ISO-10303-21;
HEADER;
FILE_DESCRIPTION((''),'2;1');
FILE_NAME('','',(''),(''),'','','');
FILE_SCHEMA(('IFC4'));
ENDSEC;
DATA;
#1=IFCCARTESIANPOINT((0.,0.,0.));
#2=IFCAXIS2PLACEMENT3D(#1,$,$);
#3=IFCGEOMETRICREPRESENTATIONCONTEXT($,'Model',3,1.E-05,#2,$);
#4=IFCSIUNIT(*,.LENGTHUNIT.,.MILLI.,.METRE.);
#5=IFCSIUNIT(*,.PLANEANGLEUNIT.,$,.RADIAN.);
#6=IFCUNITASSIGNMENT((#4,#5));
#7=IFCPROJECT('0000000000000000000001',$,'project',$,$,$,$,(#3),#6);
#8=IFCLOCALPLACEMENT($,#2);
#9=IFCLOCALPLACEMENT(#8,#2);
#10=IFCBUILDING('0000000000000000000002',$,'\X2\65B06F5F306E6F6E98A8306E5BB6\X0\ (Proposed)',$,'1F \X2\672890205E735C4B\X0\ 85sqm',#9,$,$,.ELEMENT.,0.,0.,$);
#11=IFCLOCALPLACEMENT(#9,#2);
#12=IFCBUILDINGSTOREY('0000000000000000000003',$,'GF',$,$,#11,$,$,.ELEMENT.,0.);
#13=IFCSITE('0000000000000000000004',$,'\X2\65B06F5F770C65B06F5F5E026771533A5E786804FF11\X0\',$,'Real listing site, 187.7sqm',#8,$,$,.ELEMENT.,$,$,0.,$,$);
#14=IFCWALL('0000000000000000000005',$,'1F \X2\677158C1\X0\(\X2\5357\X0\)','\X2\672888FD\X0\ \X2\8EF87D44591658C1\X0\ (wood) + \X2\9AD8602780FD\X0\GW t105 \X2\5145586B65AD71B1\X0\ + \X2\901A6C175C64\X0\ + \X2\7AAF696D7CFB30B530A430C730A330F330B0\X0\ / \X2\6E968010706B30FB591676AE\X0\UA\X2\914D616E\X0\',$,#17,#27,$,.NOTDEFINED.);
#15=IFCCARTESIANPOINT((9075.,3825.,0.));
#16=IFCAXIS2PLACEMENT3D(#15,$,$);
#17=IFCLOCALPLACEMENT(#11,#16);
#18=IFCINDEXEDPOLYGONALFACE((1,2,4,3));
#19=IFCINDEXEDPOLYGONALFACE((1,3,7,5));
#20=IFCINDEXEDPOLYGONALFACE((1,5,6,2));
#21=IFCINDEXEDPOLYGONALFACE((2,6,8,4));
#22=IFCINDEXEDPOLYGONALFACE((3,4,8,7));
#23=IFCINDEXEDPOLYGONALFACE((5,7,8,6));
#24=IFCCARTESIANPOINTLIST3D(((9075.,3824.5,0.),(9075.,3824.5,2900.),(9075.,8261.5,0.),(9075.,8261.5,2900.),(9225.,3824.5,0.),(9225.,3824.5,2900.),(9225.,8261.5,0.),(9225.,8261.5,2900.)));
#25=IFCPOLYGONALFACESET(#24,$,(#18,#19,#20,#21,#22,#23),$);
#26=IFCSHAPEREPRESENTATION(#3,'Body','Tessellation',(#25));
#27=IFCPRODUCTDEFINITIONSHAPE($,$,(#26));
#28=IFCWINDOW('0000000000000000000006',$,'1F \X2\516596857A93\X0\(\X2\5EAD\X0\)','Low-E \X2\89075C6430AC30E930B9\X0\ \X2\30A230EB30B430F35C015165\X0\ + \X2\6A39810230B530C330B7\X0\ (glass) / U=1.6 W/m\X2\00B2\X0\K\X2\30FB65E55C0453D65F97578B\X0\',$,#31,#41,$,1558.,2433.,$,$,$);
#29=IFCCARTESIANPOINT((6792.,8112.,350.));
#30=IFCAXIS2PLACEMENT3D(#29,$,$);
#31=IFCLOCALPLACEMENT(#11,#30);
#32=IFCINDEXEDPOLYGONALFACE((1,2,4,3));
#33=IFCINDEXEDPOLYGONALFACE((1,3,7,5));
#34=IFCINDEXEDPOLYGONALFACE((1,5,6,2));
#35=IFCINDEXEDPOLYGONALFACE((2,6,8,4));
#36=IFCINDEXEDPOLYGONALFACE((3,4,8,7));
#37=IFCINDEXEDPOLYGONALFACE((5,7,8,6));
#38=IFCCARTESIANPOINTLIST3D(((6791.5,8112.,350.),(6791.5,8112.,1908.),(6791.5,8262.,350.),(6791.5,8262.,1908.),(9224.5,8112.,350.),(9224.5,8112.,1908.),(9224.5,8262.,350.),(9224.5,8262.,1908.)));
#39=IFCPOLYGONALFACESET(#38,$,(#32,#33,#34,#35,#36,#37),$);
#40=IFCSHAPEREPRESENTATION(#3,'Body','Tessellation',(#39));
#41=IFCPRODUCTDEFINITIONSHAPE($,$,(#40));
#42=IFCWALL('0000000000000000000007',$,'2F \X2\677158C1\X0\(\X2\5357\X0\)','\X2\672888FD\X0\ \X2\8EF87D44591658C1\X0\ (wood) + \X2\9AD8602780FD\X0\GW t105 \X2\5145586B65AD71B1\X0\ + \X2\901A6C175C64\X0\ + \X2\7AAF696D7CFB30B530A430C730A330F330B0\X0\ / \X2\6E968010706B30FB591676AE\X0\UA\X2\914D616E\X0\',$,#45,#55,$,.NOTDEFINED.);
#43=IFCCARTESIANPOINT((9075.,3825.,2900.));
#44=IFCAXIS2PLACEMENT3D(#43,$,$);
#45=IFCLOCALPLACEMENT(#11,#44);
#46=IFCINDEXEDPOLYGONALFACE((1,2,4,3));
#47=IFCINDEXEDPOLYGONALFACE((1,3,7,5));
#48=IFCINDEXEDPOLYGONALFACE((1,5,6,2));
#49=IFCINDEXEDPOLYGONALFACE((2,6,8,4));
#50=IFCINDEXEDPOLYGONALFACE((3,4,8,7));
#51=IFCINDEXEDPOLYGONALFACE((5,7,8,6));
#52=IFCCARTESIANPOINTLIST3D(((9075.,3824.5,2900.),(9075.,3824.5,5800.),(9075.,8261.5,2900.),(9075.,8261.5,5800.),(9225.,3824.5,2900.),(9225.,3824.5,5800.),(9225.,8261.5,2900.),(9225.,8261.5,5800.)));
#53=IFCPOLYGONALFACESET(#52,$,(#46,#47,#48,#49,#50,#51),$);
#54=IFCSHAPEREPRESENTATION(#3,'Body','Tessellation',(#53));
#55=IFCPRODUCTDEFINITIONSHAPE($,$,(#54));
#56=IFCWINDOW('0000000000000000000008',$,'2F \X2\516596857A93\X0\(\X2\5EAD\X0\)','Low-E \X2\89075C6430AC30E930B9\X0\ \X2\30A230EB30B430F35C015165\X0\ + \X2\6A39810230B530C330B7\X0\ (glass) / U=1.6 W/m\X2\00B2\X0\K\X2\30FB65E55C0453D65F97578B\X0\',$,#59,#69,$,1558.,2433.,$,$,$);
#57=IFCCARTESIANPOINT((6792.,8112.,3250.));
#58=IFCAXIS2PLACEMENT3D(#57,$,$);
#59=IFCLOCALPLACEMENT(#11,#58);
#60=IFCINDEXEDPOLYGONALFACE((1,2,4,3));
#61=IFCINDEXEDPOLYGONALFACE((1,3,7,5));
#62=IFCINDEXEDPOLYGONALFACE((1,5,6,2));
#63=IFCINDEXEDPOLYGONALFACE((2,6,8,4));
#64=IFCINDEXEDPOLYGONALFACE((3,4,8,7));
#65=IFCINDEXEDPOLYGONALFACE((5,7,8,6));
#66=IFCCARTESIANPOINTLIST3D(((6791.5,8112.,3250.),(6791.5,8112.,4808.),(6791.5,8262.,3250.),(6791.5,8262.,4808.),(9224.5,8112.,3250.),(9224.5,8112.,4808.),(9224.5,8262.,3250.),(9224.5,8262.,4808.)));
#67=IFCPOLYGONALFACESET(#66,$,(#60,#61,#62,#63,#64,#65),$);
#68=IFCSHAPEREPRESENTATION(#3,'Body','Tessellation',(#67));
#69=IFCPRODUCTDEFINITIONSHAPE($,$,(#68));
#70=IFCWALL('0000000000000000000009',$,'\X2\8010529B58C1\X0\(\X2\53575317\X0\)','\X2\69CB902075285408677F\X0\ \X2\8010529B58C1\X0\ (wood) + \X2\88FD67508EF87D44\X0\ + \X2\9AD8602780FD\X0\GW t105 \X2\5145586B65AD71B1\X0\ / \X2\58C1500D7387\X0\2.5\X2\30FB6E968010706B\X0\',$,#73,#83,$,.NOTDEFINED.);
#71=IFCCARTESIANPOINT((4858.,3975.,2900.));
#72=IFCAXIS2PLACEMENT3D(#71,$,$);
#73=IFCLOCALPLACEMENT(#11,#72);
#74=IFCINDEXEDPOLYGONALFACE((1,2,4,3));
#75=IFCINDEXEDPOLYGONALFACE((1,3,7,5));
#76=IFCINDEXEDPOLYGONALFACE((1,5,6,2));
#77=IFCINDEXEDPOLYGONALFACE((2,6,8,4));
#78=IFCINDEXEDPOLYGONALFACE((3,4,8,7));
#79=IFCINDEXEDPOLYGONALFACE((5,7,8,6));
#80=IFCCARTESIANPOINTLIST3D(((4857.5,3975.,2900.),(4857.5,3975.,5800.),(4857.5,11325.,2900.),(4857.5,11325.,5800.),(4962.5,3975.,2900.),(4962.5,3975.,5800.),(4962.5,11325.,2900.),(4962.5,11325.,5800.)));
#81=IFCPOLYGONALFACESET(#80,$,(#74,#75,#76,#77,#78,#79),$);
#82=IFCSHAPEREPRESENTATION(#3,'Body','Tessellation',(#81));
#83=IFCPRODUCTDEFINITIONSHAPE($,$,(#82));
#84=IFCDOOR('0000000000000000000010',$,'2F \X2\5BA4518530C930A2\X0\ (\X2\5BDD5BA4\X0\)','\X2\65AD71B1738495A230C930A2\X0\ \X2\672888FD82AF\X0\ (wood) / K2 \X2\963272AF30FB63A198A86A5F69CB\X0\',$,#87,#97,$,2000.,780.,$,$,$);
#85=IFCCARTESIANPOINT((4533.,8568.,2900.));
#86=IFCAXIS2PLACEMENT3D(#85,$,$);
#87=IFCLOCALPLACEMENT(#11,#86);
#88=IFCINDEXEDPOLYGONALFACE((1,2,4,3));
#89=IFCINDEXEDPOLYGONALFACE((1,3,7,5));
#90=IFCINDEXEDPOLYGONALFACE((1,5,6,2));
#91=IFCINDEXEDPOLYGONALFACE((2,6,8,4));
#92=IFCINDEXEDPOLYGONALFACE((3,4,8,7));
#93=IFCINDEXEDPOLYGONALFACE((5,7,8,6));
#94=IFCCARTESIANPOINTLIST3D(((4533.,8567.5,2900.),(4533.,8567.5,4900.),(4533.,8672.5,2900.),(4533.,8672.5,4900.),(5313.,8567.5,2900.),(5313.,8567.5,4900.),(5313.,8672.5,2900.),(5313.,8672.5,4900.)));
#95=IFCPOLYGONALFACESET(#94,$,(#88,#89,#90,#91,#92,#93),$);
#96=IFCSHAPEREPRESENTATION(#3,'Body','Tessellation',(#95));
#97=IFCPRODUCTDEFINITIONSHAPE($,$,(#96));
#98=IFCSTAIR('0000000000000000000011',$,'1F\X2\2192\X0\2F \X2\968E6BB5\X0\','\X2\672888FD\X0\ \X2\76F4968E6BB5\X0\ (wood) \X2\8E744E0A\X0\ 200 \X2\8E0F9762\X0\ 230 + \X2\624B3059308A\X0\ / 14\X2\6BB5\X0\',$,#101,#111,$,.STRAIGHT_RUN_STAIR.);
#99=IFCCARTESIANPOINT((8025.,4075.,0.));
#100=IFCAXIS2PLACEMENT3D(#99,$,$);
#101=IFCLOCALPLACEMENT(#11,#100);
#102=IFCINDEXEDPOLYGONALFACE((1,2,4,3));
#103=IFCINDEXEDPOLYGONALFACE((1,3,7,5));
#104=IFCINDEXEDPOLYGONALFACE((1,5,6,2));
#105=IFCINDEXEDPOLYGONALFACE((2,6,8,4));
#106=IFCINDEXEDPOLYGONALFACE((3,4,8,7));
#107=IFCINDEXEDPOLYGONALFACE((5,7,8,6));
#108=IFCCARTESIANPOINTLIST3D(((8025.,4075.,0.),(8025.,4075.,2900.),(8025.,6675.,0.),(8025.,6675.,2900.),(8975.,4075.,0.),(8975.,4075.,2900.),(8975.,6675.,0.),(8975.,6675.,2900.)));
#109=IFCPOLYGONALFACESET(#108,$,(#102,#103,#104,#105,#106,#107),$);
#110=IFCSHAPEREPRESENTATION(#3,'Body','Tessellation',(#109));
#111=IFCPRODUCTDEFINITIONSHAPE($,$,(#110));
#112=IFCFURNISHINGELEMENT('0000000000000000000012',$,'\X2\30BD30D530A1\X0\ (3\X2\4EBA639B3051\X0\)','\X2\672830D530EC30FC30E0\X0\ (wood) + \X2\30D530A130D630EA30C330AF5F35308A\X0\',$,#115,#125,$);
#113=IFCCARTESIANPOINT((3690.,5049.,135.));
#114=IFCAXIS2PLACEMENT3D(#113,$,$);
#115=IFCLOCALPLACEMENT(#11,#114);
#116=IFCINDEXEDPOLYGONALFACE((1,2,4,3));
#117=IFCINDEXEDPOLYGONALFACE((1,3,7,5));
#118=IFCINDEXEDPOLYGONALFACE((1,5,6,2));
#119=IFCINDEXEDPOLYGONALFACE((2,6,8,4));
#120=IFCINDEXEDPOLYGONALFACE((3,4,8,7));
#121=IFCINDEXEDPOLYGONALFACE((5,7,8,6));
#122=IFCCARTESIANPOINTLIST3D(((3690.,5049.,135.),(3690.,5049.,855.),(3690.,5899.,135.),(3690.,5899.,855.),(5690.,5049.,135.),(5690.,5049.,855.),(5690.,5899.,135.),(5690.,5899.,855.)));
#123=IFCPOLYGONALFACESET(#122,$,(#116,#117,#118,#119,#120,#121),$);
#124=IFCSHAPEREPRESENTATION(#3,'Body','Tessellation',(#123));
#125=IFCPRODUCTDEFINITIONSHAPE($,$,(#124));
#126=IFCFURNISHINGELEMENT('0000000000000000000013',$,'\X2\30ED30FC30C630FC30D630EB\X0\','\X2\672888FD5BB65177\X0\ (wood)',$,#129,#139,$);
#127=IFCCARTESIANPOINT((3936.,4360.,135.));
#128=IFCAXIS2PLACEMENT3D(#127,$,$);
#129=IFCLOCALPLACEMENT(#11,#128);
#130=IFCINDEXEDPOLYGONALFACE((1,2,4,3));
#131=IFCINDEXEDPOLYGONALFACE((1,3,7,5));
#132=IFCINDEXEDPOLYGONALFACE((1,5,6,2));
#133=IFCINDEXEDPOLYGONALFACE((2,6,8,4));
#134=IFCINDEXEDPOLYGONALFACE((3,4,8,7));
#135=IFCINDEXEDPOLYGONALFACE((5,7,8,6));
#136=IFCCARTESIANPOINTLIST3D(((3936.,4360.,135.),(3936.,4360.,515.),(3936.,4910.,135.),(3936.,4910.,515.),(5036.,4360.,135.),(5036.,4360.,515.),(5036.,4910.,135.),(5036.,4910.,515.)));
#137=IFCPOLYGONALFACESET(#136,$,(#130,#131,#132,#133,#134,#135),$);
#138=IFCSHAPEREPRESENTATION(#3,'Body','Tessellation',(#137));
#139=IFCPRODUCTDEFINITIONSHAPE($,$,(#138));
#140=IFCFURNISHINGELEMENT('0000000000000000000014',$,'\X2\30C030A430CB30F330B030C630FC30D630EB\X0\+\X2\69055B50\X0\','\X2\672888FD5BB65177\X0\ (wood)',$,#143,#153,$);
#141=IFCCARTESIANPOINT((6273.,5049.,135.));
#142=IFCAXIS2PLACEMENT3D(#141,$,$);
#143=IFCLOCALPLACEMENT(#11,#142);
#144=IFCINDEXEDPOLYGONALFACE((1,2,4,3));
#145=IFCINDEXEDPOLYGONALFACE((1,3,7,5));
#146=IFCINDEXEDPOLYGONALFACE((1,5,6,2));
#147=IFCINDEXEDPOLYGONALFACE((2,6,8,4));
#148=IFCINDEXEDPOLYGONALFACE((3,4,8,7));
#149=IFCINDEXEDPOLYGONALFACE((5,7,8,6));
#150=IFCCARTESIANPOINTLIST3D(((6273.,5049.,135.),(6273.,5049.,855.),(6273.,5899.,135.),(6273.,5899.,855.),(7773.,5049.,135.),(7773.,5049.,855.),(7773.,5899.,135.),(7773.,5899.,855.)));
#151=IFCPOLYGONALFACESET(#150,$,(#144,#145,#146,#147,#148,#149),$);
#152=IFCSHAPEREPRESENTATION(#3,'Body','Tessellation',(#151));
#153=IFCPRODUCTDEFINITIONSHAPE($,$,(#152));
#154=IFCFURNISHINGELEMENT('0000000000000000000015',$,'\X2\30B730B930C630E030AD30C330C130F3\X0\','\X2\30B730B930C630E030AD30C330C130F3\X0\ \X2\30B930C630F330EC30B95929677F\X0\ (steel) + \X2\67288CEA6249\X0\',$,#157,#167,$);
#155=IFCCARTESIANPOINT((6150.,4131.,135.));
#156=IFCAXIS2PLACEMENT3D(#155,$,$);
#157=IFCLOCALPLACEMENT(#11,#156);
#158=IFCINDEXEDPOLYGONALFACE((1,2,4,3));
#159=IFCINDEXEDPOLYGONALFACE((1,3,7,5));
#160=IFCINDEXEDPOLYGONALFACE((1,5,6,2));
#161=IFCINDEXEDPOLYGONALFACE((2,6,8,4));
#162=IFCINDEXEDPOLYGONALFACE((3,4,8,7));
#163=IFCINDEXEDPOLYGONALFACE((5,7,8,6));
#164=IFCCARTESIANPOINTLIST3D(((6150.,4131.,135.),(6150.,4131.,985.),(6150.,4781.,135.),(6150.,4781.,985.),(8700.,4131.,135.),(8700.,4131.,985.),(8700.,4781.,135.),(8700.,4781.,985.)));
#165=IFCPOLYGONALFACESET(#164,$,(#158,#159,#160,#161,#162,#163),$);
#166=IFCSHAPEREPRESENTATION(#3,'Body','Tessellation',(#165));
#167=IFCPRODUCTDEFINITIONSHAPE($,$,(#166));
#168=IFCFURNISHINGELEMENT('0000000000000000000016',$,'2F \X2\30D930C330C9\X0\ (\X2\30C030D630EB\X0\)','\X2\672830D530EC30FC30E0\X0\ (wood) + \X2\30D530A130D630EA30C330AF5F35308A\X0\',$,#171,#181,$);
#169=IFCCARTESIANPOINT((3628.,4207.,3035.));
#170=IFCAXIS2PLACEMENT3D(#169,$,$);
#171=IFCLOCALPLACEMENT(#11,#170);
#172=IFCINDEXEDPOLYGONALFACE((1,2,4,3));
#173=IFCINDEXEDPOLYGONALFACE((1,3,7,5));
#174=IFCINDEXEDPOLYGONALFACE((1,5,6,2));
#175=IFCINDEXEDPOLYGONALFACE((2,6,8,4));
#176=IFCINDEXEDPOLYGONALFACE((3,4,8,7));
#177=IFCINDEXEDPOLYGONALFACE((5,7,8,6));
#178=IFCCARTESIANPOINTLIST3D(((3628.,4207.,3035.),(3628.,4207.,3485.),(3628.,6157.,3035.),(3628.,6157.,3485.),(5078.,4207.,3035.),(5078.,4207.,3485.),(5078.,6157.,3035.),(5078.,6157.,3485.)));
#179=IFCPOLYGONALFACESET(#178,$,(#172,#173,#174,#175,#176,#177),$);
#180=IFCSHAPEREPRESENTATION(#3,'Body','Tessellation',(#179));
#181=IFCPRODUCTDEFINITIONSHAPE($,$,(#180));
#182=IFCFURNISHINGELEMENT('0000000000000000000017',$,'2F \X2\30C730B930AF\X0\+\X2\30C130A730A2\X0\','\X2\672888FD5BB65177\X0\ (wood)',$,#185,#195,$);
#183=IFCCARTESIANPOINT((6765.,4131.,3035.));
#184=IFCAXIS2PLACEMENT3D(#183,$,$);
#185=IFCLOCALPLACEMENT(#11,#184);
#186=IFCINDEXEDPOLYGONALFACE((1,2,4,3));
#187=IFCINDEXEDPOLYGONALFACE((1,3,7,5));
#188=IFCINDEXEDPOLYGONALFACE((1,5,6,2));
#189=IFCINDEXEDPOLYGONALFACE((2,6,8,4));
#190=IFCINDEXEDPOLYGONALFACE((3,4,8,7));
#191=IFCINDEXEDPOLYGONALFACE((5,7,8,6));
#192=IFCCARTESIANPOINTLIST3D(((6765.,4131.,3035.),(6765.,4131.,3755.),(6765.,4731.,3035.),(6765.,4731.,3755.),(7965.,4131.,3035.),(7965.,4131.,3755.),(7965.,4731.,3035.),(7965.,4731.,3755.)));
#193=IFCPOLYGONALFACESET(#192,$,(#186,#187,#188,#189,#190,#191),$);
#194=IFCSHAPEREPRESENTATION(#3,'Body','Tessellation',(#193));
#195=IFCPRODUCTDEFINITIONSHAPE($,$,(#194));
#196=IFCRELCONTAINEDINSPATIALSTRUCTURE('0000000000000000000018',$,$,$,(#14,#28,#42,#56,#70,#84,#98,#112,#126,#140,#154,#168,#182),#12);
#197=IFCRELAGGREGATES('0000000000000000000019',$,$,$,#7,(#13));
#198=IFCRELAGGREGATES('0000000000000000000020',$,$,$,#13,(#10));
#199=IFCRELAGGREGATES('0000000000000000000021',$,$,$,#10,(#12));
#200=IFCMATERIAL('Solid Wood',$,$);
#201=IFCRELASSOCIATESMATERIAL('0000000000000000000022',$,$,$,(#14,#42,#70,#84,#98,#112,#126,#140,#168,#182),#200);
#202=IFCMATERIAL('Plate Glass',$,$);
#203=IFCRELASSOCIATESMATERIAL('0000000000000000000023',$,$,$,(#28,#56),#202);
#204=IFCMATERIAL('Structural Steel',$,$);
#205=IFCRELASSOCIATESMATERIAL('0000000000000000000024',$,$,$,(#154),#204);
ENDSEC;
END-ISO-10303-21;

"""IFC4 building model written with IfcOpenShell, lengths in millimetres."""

from ifc_helpers import new_model, si_unit, frame, frame_2d, origin, place, context, project, spatial, rectangle, extrude, material, element, fill, save


model = new_model("IFC4")

# Units and contexts
model_context = context("Model", 3, precision=1e-05, world=origin())
ifc_project = project(units=[si_unit("LENGTHUNIT", "METRE", prefix="MILLI"), si_unit("PLANEANGLEUNIT", "RADIAN")], contexts=[model_context])

# Site, building, storey
site_placement = place(None, origin())
site = spatial("IfcSite", under=ifc_project, at=site_placement, Name="新潟県新潟市東区幸栄１", ObjectType="Real listing site, 187.7sqm", CompositionType="ELEMENT", RefElevation=0.0)
building_placement = place(site_placement, origin())
building = spatial("IfcBuilding", under=site, at=building_placement, Name="新潟の潮風の家 (Proposed)", ObjectType="1F 木造平屋 85sqm", CompositionType="ELEMENT", ElevationOfRefHeight=0.0, ElevationOfTerrain=0.0)
storey_placement = place(building_placement, origin())
storey = spatial("IfcBuildingStorey", under=building, at=storey_placement, Name="GF", CompositionType="ELEMENT", Elevation=0.0)

# Wall, opening, window
ifc_material_1 = material(Name="Solid Wood")
wall_1_placement = place(storey_placement, frame((9075.0, 3825.0, 0.0)))
wall_1 = element("IfcWall", 1, at=wall_1_placement, inside=storey, material=ifc_material_1, Name="1F 東壁(南)", Description="木製 軸組外壁 (wood) + 高性能GW t105 充填断熱 + 通気層 + 窯業系サイディング / 準耐火・外皮UA配慮", PredefinedType="NOTDEFINED", context=model_context, shape_type="SweptSolid", body=[
    extrude(rectangle(XDim=150.0, YDim=4437.0, at=frame_2d((75.0, 2218.0))), frame((9075.0, 3825.0, 0.0)), (0.0, 0.0, 1.0), 2900.0),
])
opening_1_placement = place(storey_placement, frame((6792.0, 8112.0, 350.0)))
opening_1 = element("IfcOpeningElement", 2, at=opening_1_placement, cuts=wall_1, PredefinedType="NOTDEFINED", context=model_context, shape_type="SweptSolid", body=[
    extrude(rectangle(XDim=2433.0, YDim=150.0, at=frame_2d((1216.0, 75.0))), frame((6792.0, 8112.0, 350.0)), (0.0, 0.0, 1.0), 1558.0),
])
ifc_material_2 = material(Name="Plate Glass")
window_1_placement = place(storey_placement, frame((6792.0, 8112.0, 350.0)))
window_1 = element("IfcWindow", 3, at=window_1_placement, inside=storey, material=ifc_material_2, Name="1F 入隅窓(庭)", Description="Low-E 複層ガラス アルゴン封入 + 樹脂サッシ (glass) / U=1.6 W/m²K・日射取得型", OverallHeight=1558.0, OverallWidth=2433.0, context=model_context, shape_type="SweptSolid", body=[
    extrude(rectangle(XDim=2433.0, YDim=150.0, at=frame_2d((1216.0, 75.0))), frame((6792.0, 8112.0, 350.0)), (0.0, 0.0, 1.0), 1558.0),
])
fill(opening_1, window_1)

# Wall, opening, window
wall_2_placement = place(storey_placement, frame((9075.0, 3825.0, 2900.0)))
wall_2 = element("IfcWall", 4, at=wall_2_placement, inside=storey, material=ifc_material_1, Name="2F 東壁(南)", Description="木製 軸組外壁 (wood) + 高性能GW t105 充填断熱 + 通気層 + 窯業系サイディング / 準耐火・外皮UA配慮", PredefinedType="NOTDEFINED", context=model_context, shape_type="SweptSolid", body=[
    extrude(rectangle(XDim=150.0, YDim=4437.0, at=frame_2d((75.0, 2218.0))), frame((9075.0, 3825.0, 2900.0)), (0.0, 0.0, 1.0), 2900.0),
])
opening_2_placement = place(storey_placement, frame((6792.0, 8112.0, 3250.0)))
opening_2 = element("IfcOpeningElement", 5, at=opening_2_placement, cuts=wall_2, PredefinedType="NOTDEFINED", context=model_context, shape_type="SweptSolid", body=[
    extrude(rectangle(XDim=2433.0, YDim=150.0, at=frame_2d((1216.0, 75.0))), frame((6792.0, 8112.0, 3250.0)), (0.0, 0.0, 1.0), 1558.0),
])
window_2_placement = place(storey_placement, frame((6792.0, 8112.0, 3250.0)))
window_2 = element("IfcWindow", 6, at=window_2_placement, inside=storey, material=ifc_material_2, Name="2F 入隅窓(庭)", Description="Low-E 複層ガラス アルゴン封入 + 樹脂サッシ (glass) / U=1.6 W/m²K・日射取得型", OverallHeight=1558.0, OverallWidth=2433.0, context=model_context, shape_type="SweptSolid", body=[
    extrude(rectangle(XDim=2433.0, YDim=150.0, at=frame_2d((1216.0, 75.0))), frame((6792.0, 8112.0, 3250.0)), (0.0, 0.0, 1.0), 1558.0),
])
fill(opening_2, window_2)

# Wall, opening, door
wall_3_placement = place(storey_placement, frame((4858.0, 3975.0, 2900.0)))
wall_3 = element("IfcWall", 7, at=wall_3_placement, inside=storey, material=ifc_material_1, Name="耐力壁(南北)", Description="構造用合板 耐力壁 (wood) + 製材軸組 + 高性能GW t105 充填断熱 / 壁倍率2.5・準耐火", PredefinedType="NOTDEFINED", context=model_context, shape_type="SweptSolid", body=[
    extrude(rectangle(XDim=105.0, YDim=7350.0, at=frame_2d((52.0, 3675.0))), frame((4858.0, 3975.0, 2900.0)), (0.0, 0.0, 1.0), 2900.0),
])
opening_3_placement = place(storey_placement, frame((4533.0, 8568.0, 2900.0)))
opening_3 = element("IfcOpeningElement", 8, at=opening_3_placement, cuts=wall_3, PredefinedType="NOTDEFINED", context=model_context, shape_type="SweptSolid", body=[
    extrude(rectangle(XDim=780.0, YDim=105.0, at=frame_2d((390.0, 52.0))), frame((4533.0, 8568.0, 2900.0)), (0.0, 0.0, 1.0), 2000.0),
])
door_1_placement = place(storey_placement, frame((4533.0, 8568.0, 2900.0)))
door_1 = element("IfcDoor", 9, at=door_1_placement, inside=storey, material=ifc_material_1, Name="2F 室内ドア (寝室)", Description="断熱玄関ドア 木製芯 (wood) / K2 防犯・採風機構", OverallHeight=2000.0, OverallWidth=780.0, context=model_context, shape_type="SweptSolid", body=[
    extrude(rectangle(XDim=780.0, YDim=105.0, at=frame_2d((390.0, 52.0))), frame((4533.0, 8568.0, 2900.0)), (0.0, 0.0, 1.0), 2000.0),
])
fill(opening_3, door_1)

# Stair
stair_placement = place(storey_placement, frame((8025.0, 4075.0, 0.0)))
element("IfcStair", 10, at=stair_placement, inside=storey, material=ifc_material_1, Name="1F→2F 階段", Description="木製 直階段 (wood) 蹴上 200 踏面 230 + 手すり / 14段", PredefinedType="STRAIGHT_RUN_STAIR", context=model_context, shape_type="SweptSolid", body=[
    extrude(rectangle(XDim=950.0, YDim=2600.0, at=frame_2d((475.0, 1300.0))), frame((8025.0, 4075.0, 0.0)), (0.0, 0.0, 1.0), 2900.0),
])

# Furnishing elements
furnishing_1_placement = place(storey_placement, frame((3690.0, 5049.0, 135.0)))
element("IfcFurnishingElement", 11, at=furnishing_1_placement, inside=storey, material=ifc_material_1, Name="ソファ (3人掛け)", Description="木フレーム (wood) + ファブリック張り", context=model_context, shape_type="SweptSolid", body=[
    extrude(rectangle(XDim=2000.0, YDim=850.0, at=frame_2d((1000.0, 425.0))), frame((3690.0, 5049.0, 135.0)), (0.0, 0.0, 1.0), 720.0),
])
furnishing_2_placement = place(storey_placement, frame((3936.0, 4360.0, 135.0)))
element("IfcFurnishingElement", 12, at=furnishing_2_placement, inside=storey, material=ifc_material_1, Name="ローテーブル", Description="木製家具 (wood)", context=model_context, shape_type="SweptSolid", body=[
    extrude(rectangle(XDim=1100.0, YDim=550.0, at=frame_2d((550.0, 275.0))), frame((3936.0, 4360.0, 135.0)), (0.0, 0.0, 1.0), 380.0),
])
furnishing_3_placement = place(storey_placement, frame((6273.0, 5049.0, 135.0)))
element("IfcFurnishingElement", 13, at=furnishing_3_placement, inside=storey, material=ifc_material_1, Name="ダイニングテーブル+椅子", Description="木製家具 (wood)", context=model_context, shape_type="SweptSolid", body=[
    extrude(rectangle(XDim=1500.0, YDim=850.0, at=frame_2d((750.0, 425.0))), frame((6273.0, 5049.0, 135.0)), (0.0, 0.0, 1.0), 720.0),
])
ifc_material_3 = material(Name="Structural Steel")
furnishing_4_placement = place(storey_placement, frame((6150.0, 4131.0, 135.0)))
element("IfcFurnishingElement", 14, at=furnishing_4_placement, inside=storey, material=ifc_material_3, Name="システムキッチン", Description="システムキッチン ステンレス天板 (steel) + 木質扉", context=model_context, shape_type="SweptSolid", body=[
    extrude(rectangle(XDim=2550.0, YDim=650.0, at=frame_2d((1275.0, 325.0))), frame((6150.0, 4131.0, 135.0)), (0.0, 0.0, 1.0), 850.0),
])
furnishing_5_placement = place(storey_placement, frame((3628.0, 4207.0, 3035.0)))
element("IfcFurnishingElement", 15, at=furnishing_5_placement, inside=storey, material=ifc_material_1, Name="2F ベッド (ダブル)", Description="木フレーム (wood) + ファブリック張り", context=model_context, shape_type="SweptSolid", body=[
    extrude(rectangle(XDim=1450.0, YDim=1950.0, at=frame_2d((725.0, 975.0))), frame((3628.0, 4207.0, 3035.0)), (0.0, 0.0, 1.0), 450.0),
])
furnishing_6_placement = place(storey_placement, frame((6765.0, 4131.0, 3035.0)))
element("IfcFurnishingElement", 16, at=furnishing_6_placement, inside=storey, material=ifc_material_1, Name="2F デスク+チェア", Description="木製家具 (wood)", context=model_context, shape_type="SweptSolid", body=[
    extrude(rectangle(XDim=1200.0, YDim=600.0, at=frame_2d((600.0, 300.0))), frame((6765.0, 4131.0, 3035.0)), (0.0, 0.0, 1.0), 720.0),
])

save(model, "model.ifc")
